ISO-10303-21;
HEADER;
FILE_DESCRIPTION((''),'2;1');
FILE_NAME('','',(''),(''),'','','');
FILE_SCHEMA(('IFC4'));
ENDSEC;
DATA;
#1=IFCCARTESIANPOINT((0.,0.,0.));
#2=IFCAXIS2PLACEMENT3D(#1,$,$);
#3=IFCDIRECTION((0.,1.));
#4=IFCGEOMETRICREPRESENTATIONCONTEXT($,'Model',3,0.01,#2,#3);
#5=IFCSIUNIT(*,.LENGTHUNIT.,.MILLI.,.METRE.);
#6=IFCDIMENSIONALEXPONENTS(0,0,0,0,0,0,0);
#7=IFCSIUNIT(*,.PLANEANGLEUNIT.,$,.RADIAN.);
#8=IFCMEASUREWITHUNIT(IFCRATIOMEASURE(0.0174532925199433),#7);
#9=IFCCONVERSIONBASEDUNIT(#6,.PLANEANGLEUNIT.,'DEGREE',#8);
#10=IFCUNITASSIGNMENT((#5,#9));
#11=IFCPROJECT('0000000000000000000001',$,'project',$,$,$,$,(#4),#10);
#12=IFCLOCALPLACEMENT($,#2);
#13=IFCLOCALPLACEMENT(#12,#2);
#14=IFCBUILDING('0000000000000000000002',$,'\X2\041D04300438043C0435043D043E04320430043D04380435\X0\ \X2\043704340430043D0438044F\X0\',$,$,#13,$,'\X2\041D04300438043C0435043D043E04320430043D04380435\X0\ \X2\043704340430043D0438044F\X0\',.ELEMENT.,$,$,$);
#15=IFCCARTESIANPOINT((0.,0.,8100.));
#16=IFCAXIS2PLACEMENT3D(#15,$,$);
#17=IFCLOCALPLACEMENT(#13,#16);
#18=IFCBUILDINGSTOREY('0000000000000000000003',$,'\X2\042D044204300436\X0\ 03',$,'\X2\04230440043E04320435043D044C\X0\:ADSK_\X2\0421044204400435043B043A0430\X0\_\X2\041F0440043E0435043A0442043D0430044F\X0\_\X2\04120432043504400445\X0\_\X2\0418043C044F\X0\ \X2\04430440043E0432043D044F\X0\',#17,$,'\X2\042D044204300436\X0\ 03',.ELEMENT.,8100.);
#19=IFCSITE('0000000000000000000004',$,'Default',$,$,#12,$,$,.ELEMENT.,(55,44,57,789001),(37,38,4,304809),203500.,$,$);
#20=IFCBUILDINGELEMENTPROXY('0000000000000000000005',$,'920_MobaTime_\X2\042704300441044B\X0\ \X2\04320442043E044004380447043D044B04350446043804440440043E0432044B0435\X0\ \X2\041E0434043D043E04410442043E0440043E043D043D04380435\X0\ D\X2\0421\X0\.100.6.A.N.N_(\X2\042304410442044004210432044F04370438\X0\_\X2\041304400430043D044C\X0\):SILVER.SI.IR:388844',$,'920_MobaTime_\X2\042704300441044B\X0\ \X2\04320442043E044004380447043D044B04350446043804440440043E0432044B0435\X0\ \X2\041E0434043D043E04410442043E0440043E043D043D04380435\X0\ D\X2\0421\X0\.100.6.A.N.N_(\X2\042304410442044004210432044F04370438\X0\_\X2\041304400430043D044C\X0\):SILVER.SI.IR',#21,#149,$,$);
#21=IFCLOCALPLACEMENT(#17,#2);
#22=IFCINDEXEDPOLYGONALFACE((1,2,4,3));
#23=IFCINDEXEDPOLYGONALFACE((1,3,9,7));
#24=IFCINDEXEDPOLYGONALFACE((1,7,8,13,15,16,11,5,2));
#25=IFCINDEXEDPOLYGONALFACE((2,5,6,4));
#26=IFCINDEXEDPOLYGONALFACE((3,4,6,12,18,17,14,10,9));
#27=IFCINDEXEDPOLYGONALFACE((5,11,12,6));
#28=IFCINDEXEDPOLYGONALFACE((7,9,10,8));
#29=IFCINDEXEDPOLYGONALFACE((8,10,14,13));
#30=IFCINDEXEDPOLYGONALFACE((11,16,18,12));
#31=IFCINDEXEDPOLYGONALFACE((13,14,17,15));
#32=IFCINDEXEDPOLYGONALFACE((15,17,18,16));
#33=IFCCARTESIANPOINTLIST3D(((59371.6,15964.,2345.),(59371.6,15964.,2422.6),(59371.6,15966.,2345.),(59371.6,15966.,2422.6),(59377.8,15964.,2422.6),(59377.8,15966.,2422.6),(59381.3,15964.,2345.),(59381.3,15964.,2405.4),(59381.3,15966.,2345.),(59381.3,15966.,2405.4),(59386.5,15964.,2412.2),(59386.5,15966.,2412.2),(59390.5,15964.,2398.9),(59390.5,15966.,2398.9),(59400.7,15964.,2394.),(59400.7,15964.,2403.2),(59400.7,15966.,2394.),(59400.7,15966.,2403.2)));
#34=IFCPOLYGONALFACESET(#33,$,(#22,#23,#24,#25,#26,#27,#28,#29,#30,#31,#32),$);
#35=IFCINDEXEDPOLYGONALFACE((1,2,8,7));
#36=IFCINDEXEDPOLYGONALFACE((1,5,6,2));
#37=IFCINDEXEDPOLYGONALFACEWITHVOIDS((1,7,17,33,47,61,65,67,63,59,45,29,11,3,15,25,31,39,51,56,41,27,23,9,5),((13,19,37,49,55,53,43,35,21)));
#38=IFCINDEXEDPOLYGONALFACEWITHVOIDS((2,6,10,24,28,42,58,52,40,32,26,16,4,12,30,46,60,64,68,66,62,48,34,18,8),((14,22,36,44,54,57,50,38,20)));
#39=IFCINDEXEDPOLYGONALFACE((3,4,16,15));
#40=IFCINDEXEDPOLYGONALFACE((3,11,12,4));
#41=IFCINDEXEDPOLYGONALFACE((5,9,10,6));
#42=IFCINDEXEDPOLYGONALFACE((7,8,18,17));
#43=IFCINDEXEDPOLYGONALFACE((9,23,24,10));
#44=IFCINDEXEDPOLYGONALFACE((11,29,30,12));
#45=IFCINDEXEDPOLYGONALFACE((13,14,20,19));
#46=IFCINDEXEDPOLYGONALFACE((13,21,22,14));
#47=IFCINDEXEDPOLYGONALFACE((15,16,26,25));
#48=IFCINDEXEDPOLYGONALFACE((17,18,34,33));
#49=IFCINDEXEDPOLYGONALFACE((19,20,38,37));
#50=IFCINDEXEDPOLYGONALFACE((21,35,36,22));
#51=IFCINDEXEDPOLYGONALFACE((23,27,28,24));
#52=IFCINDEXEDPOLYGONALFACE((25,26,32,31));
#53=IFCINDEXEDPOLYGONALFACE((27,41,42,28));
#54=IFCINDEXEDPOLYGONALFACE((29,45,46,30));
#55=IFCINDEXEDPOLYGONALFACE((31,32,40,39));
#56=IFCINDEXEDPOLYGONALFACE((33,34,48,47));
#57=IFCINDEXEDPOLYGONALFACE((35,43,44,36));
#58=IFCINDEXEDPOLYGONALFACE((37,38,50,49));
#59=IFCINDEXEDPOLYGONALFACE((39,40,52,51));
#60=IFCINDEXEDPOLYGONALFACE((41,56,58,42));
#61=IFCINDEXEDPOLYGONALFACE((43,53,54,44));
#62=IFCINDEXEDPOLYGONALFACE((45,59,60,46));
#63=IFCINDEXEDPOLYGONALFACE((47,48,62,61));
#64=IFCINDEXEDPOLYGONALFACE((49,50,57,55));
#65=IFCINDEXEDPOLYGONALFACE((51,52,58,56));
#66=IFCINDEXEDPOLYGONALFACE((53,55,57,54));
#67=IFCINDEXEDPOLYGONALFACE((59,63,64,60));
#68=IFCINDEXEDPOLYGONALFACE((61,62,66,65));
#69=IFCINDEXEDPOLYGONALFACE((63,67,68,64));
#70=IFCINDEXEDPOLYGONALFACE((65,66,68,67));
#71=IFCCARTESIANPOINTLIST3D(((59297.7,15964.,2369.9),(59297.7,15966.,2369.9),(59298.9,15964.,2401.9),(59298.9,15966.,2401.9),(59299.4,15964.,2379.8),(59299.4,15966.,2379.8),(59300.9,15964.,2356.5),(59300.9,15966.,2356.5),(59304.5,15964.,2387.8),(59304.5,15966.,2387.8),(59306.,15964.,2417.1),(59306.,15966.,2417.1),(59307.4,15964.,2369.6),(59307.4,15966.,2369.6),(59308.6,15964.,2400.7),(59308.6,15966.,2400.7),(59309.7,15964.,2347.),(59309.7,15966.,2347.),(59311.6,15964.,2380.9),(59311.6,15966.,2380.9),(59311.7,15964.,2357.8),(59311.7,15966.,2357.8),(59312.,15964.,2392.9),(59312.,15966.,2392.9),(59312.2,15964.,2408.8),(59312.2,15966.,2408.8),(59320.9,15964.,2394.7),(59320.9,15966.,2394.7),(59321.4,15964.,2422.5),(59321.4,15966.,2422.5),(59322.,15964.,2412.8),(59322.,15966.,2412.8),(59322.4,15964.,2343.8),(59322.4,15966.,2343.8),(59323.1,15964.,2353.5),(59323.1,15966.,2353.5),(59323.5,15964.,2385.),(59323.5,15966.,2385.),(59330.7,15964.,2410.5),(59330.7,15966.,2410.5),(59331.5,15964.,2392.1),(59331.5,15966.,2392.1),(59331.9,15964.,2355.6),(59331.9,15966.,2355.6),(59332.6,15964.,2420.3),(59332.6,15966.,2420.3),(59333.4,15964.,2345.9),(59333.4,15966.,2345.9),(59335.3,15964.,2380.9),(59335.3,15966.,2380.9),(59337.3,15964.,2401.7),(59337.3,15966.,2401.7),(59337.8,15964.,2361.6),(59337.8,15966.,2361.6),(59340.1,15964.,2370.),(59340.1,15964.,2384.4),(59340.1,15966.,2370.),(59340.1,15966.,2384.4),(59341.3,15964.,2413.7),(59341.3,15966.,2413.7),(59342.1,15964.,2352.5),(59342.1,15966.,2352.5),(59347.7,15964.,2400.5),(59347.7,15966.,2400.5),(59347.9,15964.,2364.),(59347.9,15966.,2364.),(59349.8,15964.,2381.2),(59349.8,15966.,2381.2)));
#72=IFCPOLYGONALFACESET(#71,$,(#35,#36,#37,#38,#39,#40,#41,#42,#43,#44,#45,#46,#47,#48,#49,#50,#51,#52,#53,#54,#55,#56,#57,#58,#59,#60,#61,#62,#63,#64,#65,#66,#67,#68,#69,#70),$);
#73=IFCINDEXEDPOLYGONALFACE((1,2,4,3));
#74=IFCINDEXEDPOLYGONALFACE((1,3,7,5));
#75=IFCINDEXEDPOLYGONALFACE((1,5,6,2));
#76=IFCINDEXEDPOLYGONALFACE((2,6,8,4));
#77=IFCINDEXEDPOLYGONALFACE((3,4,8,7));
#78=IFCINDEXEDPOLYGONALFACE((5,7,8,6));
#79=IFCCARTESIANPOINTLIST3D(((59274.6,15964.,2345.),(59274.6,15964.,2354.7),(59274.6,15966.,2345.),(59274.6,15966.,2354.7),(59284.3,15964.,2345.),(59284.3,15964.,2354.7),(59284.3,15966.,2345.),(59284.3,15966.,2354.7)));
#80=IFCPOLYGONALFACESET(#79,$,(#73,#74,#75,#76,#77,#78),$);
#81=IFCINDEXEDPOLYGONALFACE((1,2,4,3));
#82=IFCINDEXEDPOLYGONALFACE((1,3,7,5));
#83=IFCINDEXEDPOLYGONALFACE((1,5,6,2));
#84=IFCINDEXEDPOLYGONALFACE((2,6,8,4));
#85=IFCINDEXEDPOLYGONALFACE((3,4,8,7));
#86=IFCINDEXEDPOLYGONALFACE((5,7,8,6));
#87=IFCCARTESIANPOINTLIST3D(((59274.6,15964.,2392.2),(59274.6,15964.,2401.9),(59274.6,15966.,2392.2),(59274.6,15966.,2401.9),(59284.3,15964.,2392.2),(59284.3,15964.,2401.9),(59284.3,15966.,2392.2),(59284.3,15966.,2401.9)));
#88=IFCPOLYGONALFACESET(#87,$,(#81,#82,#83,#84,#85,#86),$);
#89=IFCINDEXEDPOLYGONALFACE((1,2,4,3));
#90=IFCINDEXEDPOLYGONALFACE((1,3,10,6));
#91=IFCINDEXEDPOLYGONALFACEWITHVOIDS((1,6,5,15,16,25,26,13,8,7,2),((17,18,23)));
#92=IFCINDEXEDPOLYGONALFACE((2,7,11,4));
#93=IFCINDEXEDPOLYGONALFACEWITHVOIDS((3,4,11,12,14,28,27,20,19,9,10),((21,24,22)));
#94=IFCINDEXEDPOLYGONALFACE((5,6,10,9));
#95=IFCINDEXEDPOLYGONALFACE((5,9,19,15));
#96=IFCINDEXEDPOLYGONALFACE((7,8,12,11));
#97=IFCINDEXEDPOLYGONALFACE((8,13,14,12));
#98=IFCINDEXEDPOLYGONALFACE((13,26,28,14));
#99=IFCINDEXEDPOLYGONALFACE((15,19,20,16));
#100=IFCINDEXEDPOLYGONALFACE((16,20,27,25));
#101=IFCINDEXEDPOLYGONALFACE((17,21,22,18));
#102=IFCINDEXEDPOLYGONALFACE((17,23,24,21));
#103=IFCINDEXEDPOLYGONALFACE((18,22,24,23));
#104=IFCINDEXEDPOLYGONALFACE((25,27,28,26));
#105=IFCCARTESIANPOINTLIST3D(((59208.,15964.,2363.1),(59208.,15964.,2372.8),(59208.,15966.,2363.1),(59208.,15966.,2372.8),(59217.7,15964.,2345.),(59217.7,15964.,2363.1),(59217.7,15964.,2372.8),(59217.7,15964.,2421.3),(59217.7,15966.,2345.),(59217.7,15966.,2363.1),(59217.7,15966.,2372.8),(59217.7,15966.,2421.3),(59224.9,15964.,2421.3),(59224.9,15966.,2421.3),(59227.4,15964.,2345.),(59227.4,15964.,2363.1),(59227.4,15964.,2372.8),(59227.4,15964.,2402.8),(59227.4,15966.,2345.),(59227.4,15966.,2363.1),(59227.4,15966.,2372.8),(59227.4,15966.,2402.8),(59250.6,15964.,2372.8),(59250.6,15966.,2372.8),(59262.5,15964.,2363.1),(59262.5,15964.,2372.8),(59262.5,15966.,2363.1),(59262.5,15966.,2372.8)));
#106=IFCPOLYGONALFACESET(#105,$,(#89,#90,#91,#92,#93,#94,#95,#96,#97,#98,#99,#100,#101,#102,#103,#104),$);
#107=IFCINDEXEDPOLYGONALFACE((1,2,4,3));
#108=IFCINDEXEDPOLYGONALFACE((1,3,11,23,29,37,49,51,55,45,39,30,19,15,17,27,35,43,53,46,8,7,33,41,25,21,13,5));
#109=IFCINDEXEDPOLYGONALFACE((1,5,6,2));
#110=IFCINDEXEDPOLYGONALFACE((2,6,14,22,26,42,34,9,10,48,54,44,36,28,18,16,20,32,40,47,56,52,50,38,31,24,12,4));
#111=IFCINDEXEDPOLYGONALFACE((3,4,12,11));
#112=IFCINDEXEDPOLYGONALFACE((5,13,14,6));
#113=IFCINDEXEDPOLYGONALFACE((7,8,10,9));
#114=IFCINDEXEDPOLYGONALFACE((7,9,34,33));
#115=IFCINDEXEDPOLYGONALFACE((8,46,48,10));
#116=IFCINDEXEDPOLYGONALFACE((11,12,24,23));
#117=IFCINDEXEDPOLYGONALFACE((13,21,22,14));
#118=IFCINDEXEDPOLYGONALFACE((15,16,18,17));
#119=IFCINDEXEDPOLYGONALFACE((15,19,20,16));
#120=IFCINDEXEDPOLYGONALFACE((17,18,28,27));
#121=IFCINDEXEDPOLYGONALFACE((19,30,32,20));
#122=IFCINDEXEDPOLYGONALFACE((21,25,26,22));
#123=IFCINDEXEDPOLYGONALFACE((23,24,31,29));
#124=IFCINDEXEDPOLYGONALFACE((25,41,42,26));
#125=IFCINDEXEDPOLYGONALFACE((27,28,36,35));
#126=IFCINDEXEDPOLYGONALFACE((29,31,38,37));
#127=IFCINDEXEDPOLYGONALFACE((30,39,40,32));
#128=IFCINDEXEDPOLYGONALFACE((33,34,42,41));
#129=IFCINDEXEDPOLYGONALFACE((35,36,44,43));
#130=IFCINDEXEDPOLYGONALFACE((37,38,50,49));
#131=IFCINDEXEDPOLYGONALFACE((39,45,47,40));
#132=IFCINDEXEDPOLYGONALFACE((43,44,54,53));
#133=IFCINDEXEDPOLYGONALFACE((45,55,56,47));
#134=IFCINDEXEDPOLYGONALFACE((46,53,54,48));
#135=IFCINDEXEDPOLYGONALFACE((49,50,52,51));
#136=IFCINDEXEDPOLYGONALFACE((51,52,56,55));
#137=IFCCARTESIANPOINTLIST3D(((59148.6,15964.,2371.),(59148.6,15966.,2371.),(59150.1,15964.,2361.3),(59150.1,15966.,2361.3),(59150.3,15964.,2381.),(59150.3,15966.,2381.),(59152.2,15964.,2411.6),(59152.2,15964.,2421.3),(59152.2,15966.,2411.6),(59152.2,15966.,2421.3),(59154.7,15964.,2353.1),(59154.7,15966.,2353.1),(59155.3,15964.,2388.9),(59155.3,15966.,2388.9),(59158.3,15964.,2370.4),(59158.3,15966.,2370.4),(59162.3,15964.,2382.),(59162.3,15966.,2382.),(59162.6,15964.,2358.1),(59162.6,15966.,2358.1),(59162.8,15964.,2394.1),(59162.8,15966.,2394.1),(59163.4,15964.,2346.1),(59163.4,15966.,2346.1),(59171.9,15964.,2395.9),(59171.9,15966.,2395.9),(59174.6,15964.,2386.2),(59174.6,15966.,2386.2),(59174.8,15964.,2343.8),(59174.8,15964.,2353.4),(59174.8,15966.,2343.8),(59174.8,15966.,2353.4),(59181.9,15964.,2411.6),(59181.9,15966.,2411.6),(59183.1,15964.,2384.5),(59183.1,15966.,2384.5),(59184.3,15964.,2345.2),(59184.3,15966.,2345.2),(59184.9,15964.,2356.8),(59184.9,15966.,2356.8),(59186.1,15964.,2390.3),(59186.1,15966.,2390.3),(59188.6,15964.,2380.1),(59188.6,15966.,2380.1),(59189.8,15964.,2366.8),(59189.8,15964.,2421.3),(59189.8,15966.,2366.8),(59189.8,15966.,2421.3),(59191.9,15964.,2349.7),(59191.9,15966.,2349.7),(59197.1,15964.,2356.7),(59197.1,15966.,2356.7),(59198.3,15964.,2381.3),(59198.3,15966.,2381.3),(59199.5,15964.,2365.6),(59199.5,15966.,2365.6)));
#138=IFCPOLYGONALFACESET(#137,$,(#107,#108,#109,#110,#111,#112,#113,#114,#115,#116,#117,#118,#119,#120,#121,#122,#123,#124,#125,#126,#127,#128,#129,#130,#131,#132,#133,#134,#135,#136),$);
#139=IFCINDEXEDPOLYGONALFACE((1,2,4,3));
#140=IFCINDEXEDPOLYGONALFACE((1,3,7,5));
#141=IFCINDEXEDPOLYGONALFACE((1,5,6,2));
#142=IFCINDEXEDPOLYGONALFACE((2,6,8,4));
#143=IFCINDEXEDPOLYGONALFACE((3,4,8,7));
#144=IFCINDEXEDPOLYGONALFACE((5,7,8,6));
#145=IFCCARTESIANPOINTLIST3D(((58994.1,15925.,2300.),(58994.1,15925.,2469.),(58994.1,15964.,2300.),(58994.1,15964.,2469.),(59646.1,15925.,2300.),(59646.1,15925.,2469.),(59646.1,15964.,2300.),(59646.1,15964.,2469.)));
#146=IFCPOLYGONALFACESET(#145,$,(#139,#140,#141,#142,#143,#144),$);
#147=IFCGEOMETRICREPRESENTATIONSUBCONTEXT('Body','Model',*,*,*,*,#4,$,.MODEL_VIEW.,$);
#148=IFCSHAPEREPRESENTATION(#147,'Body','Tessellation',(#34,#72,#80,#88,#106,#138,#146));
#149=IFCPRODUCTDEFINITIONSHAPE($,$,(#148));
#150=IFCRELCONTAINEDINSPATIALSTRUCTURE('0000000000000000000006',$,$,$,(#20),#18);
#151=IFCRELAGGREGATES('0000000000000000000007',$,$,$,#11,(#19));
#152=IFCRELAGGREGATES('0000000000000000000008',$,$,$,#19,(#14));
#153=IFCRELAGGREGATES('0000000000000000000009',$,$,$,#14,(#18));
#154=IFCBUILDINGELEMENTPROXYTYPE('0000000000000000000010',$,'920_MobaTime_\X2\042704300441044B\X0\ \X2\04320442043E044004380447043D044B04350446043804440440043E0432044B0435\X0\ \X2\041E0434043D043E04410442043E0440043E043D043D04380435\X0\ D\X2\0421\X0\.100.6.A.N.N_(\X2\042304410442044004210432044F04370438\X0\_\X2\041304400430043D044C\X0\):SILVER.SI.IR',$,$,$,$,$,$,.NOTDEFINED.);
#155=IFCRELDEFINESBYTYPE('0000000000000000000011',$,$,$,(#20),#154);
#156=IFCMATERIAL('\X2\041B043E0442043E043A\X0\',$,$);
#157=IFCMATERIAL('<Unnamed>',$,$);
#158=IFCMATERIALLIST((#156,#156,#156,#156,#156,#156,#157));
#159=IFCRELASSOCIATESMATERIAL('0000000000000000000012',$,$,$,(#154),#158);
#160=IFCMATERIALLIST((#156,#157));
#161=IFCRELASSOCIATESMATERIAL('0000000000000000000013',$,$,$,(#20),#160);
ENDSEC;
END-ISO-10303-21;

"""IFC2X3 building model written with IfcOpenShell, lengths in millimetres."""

from ifc_helpers import new_model, entity, si_unit, converted_unit, direction, frame, origin, origin_2d_with_axis, place, context, subcontext, project, spatial, polyline, rectangle, outline, extrude, source, transform, mapped, material, material_list, type_object, type_shapes, element, save


model = new_model("IFC2X3")

# Units and contexts
model_context = context("Model", 3, precision=0.01, world=origin(), true_north=direction((0.0, 1.0)))
body_context = subcontext(model_context, "Body", "Model", "MODEL_VIEW")
ifc_project = project(units=[si_unit("LENGTHUNIT", "METRE", prefix="MILLI"), converted_unit("PLANEANGLEUNIT", "DEGREE", entity("IfcRatioMeasure", 0.0174532925199433), si_unit("PLANEANGLEUNIT", "RADIAN"), dimensions=[0, 0, 0, 0, 0, 0, 0])], contexts=[model_context])

# Site, building, storey
site_placement = place(None, origin())
site = spatial("IfcSite", under=ifc_project, at=site_placement, Name="Default", CompositionType="ELEMENT", RefLatitude=(55, 44, 57, 789001), RefLongitude=(37, 38, 4, 304809), RefElevation=203500.0)
building_placement = place(site_placement, origin())
building = spatial("IfcBuilding", under=site, at=building_placement, Name="Наименование здания", LongName="Наименование здания", CompositionType="ELEMENT")
storey_placement = place(building_placement, frame((0.0, 0.0, 8100.0)))
storey = spatial("IfcBuildingStorey", under=building, at=storey_placement, Name="Этаж 03", ObjectType="Уровень:ADSK_Стрелка_Проектная_Вверх_Имя уровня", LongName="Этаж 03", CompositionType="ELEMENT", Elevation=8100.0)

# Building element proxy
ifc_material_1 = material(Name="Лоток")
ifc_material_2 = material(Name="<Unnamed>")
ifc_material_list_1 = material_list([ifc_material_1, ifc_material_1, ifc_material_1, ifc_material_1, ifc_material_1, ifc_material_1, ifc_material_2])
building_element_proxy_type = type_object("IfcBuildingElementProxyType", Name="920_MobaTime_Часы вторичныецифровые Односторонние DС.100.6.A.N.N_(УстрСвязи_Грань):SILVER.SI.IR", PredefinedType="NOTDEFINED", material=ifc_material_list_1)
shared_shape = source(origin(), body_context, "Body", "SweptSolid", [
    extrude(outline(polyline([(-49.3, -13.1), (28.2, -13.1), (28.2, -6.8), (17.9, 1.8), (8.8, 16.0), (-0.3, 16.0), (4.6, 5.8), (11.1, -3.4), (-49.3, -3.4), (-49.3, -13.1)])), frame((-64.6, 9.8, 39.0), z_axis=(0.0, 0.0, 1.0), x_axis=(0.0, 1.0, 0.0)), (0.0, 0.0, 1.0), 2.0),
    extrude(outline(polyline([(2.2, -27.6), (19.0, -27.6), (30.5, -16.1), (33.3, -4.9), (31.0, 5.8), (21.8, 17.2), (5.2, 27.3), (-11.1, 33.0), (-24.0, 32.7), (-33.6, 27.6), (-40.3, 18.6), (-42.8, 5.7), (-38.0, -6.3), (-27.2, -14.9), (-17.5, -17.7), (-8.2, -16.4), (-0.3, -11.9), (5.1, -4.5), (7.3, 6.2), (4.0, 17.2), (18.4, 7.3), (23.6, -2.4), (22.0, -11.4), (14.2, -18.4), (5.3, -18.3), (2.2, -27.6)]), holes=[polyline([(-9.0, 23.3), (-1.3, 14.3), (-2.5, 2.0), (-11.4, -7.0), (-23.4, -6.0), (-32.2, 2.9), (-31.2, 15.1), (-25.6, 22.1), (-17.5, 24.9), (-9.0, 23.3)])]), frame((-2.7, 3.6, 39.0), z_axis=(0.0, 0.0, 1.0), x_axis=(-0.427649, 0.903945, 0.0)), (0.0, 0.0, 1.0), 2.0),
    extrude(rectangle(XDim=9.7, YDim=9.7, at=origin_2d_with_axis()), frame((40.6, -34.7, 39.0)), (0.0, 0.0, 1.0), 2.0),
    extrude(rectangle(XDim=9.7, YDim=9.7, at=origin_2d_with_axis()), frame((40.6, 12.6, 39.0)), (0.0, 0.0, 1.0), 2.0),
    extrude(outline(polyline([(-0.9, -28.1), (8.8, -28.1), (8.8, -9.9), (18.5, -9.9), (18.5, -0.2), (8.8, -0.2), (8.8, 48.3), (1.5, 48.3), (-36.0, -0.2), (-36.0, -9.9), (-0.9, -9.9), (-0.9, -28.1)]), holes=[polyline([(-0.9, -0.2), (-24.1, -0.2), (-0.9, 29.7), (-0.9, -0.2)])]), frame((93.6, -11.4, 39.0)), (0.0, 0.0, 1.0), 2.0),
    extrude(outline(polyline([(3.3, -28.3), (12.5, -28.3), (20.5, -25.0), (26.8, -18.9), (30.7, -10.0), (31.4, 1.6), (26.9, 11.8), (20.1, 18.4), (11.1, 22.3), (1.0, 23.3), (-7.9, 20.4), (-14.9, 14.5), (-18.9, 6.2), (-17.1, -9.0), (-36.7, 0.5), (-29.1, 29.2), (-38.5, 31.7), (-48.1, -4.6), (-11.6, -23.1), (-8.0, -14.0), (-10.8, -7.6), (-10.2, 1.1), (-3.0, 11.8), (9.2, 12.8), (20.0, 5.5), (21.4, -7.5), (15.5, -16.4), (4.6, -18.6), (3.3, -28.3)])), frame((147.1, -8.5, 39.0), z_axis=(0.0, 0.0, 1.0), x_axis=(0.256974, -0.966418, 0.0)), (0.0, 0.0, 1.0), 2.0),
    extrude(rectangle(XDim=652.0, YDim=169.0, at=origin_2d_with_axis()), frame((0.0, 0.0, 0.0), z_axis=(0.0, 0.0, 1.0), x_axis=(-1.0, 0.0, 0.0)), (0.0, 0.0, 1.0), 39.0),
])
type_shapes(building_element_proxy_type, [shared_shape])
ifc_material_list_2 = material_list([ifc_material_1, ifc_material_2])
for number, where, z_axis, x_axis, name in (
    (1, (59320.1, 15925.0, 2384.5), (0.0, 1.0, 0.0), (-1.0, 0.0, 0.0), "920_MobaTime_Часы вторичныецифровые Односторонние DС.100.6.A.N.N_(УстрСвязи_Грань):SILVER.SI.IR:388844"),
):
    element("IfcBuildingElementProxy", number, at=place(storey_placement, frame(where, z_axis=z_axis, x_axis=x_axis)), inside=storey, type_object=building_element_proxy_type, material=ifc_material_list_2, Name=name, ObjectType="920_MobaTime_Часы вторичныецифровые Односторонние DС.100.6.A.N.N_(УстрСвязи_Грань):SILVER.SI.IR", context=body_context, shape_type="MappedRepresentation", body=[
        mapped(shared_shape, transform((0.0, 0.0, 0.0), scale=1.0)),
    ])

save(model, "model.ifc")
